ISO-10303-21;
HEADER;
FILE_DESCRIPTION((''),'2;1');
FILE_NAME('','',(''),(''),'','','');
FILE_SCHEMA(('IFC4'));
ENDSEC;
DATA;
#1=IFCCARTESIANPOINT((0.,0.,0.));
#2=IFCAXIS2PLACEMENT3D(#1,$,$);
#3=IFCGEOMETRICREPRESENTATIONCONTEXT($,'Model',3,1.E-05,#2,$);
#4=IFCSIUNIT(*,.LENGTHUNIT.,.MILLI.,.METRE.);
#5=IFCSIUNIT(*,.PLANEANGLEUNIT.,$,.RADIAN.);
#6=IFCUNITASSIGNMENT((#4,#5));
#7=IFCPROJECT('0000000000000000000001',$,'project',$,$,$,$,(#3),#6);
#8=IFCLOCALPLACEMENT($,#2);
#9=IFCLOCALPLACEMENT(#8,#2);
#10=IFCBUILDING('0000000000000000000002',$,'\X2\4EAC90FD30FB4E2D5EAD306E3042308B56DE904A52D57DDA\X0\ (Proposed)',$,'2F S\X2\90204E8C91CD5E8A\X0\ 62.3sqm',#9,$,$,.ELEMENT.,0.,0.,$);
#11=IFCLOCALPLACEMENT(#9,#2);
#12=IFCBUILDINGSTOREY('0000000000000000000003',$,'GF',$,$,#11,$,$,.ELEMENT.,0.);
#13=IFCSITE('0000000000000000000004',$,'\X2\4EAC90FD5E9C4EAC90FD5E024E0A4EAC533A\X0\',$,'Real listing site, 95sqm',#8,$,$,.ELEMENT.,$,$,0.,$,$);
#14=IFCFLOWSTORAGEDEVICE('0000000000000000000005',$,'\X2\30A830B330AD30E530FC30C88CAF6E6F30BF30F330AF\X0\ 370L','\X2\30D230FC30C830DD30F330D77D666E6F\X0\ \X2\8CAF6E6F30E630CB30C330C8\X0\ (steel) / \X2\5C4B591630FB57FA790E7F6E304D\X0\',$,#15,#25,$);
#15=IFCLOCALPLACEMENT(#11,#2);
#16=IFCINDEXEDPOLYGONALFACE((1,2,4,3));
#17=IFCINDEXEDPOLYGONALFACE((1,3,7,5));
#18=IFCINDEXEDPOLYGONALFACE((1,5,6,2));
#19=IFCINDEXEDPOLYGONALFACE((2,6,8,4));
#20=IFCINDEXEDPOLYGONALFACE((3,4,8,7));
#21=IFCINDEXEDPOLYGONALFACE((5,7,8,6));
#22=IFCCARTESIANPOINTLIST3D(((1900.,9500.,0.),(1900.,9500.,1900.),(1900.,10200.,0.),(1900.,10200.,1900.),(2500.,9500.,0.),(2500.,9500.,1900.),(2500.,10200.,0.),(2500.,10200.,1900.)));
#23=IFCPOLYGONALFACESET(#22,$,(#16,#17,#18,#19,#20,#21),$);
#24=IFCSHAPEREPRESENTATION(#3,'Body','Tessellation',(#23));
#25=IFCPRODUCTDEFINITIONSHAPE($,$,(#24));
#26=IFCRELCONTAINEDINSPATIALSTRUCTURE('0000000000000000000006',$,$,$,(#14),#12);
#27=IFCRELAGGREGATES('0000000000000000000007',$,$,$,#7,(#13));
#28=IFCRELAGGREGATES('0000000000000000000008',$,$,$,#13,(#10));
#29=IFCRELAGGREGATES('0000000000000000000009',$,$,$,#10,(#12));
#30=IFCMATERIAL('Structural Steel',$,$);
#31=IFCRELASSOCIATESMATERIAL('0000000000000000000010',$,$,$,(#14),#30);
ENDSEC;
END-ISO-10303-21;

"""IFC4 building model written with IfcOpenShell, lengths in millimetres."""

from ifc_helpers import new_model, si_unit, frame, frame_2d, origin, place, context, project, spatial, rectangle, extrude, material, element, save


model = new_model("IFC4")

# Units and contexts
model_context = context("Model", 3, precision=1e-05, world=origin())
ifc_project = project(units=[si_unit("LENGTHUNIT", "METRE", prefix="MILLI"), si_unit("PLANEANGLEUNIT", "RADIAN")], contexts=[model_context])

# Site, building, storey
site_placement = place(None, origin())
site = spatial("IfcSite", under=ifc_project, at=site_placement, Name="京都府京都市上京区", ObjectType="Real listing site, 95sqm", CompositionType="ELEMENT", RefElevation=0.0)
building_placement = place(site_placement, origin())
building = spatial("IfcBuilding", under=site, at=building_placement, Name="京都・中庭のある回遊動線 (Proposed)", ObjectType="2F S造二重床 62.3sqm", CompositionType="ELEMENT", ElevationOfRefHeight=0.0, ElevationOfTerrain=0.0)
storey_placement = place(building_placement, origin())
storey = spatial("IfcBuildingStorey", under=building, at=storey_placement, Name="GF", CompositionType="ELEMENT", Elevation=0.0)

# Flow storage device
ifc_material_1 = material(Name="Structural Steel")
flow_storage_device_placement = place(storey_placement, frame((950.0, 4750.0, 0.0)))
element("IfcFlowStorageDevice", 1, at=flow_storage_device_placement, inside=storey, material=ifc_material_1, Name="エコキュート貯湯タンク 370L", Description="ヒートポンプ給湯 貯湯ユニット (steel) / 屋外・基礎置き", context=model_context, shape_type="SweptSolid", body=[
    extrude(rectangle(XDim=600.0, YDim=700.0, at=frame_2d((300.0, 350.0))), frame((950.0, 4750.0, 0.0)), (0.0, 0.0, 1.0), 1900.0),
])

save(model, "model.ifc")
